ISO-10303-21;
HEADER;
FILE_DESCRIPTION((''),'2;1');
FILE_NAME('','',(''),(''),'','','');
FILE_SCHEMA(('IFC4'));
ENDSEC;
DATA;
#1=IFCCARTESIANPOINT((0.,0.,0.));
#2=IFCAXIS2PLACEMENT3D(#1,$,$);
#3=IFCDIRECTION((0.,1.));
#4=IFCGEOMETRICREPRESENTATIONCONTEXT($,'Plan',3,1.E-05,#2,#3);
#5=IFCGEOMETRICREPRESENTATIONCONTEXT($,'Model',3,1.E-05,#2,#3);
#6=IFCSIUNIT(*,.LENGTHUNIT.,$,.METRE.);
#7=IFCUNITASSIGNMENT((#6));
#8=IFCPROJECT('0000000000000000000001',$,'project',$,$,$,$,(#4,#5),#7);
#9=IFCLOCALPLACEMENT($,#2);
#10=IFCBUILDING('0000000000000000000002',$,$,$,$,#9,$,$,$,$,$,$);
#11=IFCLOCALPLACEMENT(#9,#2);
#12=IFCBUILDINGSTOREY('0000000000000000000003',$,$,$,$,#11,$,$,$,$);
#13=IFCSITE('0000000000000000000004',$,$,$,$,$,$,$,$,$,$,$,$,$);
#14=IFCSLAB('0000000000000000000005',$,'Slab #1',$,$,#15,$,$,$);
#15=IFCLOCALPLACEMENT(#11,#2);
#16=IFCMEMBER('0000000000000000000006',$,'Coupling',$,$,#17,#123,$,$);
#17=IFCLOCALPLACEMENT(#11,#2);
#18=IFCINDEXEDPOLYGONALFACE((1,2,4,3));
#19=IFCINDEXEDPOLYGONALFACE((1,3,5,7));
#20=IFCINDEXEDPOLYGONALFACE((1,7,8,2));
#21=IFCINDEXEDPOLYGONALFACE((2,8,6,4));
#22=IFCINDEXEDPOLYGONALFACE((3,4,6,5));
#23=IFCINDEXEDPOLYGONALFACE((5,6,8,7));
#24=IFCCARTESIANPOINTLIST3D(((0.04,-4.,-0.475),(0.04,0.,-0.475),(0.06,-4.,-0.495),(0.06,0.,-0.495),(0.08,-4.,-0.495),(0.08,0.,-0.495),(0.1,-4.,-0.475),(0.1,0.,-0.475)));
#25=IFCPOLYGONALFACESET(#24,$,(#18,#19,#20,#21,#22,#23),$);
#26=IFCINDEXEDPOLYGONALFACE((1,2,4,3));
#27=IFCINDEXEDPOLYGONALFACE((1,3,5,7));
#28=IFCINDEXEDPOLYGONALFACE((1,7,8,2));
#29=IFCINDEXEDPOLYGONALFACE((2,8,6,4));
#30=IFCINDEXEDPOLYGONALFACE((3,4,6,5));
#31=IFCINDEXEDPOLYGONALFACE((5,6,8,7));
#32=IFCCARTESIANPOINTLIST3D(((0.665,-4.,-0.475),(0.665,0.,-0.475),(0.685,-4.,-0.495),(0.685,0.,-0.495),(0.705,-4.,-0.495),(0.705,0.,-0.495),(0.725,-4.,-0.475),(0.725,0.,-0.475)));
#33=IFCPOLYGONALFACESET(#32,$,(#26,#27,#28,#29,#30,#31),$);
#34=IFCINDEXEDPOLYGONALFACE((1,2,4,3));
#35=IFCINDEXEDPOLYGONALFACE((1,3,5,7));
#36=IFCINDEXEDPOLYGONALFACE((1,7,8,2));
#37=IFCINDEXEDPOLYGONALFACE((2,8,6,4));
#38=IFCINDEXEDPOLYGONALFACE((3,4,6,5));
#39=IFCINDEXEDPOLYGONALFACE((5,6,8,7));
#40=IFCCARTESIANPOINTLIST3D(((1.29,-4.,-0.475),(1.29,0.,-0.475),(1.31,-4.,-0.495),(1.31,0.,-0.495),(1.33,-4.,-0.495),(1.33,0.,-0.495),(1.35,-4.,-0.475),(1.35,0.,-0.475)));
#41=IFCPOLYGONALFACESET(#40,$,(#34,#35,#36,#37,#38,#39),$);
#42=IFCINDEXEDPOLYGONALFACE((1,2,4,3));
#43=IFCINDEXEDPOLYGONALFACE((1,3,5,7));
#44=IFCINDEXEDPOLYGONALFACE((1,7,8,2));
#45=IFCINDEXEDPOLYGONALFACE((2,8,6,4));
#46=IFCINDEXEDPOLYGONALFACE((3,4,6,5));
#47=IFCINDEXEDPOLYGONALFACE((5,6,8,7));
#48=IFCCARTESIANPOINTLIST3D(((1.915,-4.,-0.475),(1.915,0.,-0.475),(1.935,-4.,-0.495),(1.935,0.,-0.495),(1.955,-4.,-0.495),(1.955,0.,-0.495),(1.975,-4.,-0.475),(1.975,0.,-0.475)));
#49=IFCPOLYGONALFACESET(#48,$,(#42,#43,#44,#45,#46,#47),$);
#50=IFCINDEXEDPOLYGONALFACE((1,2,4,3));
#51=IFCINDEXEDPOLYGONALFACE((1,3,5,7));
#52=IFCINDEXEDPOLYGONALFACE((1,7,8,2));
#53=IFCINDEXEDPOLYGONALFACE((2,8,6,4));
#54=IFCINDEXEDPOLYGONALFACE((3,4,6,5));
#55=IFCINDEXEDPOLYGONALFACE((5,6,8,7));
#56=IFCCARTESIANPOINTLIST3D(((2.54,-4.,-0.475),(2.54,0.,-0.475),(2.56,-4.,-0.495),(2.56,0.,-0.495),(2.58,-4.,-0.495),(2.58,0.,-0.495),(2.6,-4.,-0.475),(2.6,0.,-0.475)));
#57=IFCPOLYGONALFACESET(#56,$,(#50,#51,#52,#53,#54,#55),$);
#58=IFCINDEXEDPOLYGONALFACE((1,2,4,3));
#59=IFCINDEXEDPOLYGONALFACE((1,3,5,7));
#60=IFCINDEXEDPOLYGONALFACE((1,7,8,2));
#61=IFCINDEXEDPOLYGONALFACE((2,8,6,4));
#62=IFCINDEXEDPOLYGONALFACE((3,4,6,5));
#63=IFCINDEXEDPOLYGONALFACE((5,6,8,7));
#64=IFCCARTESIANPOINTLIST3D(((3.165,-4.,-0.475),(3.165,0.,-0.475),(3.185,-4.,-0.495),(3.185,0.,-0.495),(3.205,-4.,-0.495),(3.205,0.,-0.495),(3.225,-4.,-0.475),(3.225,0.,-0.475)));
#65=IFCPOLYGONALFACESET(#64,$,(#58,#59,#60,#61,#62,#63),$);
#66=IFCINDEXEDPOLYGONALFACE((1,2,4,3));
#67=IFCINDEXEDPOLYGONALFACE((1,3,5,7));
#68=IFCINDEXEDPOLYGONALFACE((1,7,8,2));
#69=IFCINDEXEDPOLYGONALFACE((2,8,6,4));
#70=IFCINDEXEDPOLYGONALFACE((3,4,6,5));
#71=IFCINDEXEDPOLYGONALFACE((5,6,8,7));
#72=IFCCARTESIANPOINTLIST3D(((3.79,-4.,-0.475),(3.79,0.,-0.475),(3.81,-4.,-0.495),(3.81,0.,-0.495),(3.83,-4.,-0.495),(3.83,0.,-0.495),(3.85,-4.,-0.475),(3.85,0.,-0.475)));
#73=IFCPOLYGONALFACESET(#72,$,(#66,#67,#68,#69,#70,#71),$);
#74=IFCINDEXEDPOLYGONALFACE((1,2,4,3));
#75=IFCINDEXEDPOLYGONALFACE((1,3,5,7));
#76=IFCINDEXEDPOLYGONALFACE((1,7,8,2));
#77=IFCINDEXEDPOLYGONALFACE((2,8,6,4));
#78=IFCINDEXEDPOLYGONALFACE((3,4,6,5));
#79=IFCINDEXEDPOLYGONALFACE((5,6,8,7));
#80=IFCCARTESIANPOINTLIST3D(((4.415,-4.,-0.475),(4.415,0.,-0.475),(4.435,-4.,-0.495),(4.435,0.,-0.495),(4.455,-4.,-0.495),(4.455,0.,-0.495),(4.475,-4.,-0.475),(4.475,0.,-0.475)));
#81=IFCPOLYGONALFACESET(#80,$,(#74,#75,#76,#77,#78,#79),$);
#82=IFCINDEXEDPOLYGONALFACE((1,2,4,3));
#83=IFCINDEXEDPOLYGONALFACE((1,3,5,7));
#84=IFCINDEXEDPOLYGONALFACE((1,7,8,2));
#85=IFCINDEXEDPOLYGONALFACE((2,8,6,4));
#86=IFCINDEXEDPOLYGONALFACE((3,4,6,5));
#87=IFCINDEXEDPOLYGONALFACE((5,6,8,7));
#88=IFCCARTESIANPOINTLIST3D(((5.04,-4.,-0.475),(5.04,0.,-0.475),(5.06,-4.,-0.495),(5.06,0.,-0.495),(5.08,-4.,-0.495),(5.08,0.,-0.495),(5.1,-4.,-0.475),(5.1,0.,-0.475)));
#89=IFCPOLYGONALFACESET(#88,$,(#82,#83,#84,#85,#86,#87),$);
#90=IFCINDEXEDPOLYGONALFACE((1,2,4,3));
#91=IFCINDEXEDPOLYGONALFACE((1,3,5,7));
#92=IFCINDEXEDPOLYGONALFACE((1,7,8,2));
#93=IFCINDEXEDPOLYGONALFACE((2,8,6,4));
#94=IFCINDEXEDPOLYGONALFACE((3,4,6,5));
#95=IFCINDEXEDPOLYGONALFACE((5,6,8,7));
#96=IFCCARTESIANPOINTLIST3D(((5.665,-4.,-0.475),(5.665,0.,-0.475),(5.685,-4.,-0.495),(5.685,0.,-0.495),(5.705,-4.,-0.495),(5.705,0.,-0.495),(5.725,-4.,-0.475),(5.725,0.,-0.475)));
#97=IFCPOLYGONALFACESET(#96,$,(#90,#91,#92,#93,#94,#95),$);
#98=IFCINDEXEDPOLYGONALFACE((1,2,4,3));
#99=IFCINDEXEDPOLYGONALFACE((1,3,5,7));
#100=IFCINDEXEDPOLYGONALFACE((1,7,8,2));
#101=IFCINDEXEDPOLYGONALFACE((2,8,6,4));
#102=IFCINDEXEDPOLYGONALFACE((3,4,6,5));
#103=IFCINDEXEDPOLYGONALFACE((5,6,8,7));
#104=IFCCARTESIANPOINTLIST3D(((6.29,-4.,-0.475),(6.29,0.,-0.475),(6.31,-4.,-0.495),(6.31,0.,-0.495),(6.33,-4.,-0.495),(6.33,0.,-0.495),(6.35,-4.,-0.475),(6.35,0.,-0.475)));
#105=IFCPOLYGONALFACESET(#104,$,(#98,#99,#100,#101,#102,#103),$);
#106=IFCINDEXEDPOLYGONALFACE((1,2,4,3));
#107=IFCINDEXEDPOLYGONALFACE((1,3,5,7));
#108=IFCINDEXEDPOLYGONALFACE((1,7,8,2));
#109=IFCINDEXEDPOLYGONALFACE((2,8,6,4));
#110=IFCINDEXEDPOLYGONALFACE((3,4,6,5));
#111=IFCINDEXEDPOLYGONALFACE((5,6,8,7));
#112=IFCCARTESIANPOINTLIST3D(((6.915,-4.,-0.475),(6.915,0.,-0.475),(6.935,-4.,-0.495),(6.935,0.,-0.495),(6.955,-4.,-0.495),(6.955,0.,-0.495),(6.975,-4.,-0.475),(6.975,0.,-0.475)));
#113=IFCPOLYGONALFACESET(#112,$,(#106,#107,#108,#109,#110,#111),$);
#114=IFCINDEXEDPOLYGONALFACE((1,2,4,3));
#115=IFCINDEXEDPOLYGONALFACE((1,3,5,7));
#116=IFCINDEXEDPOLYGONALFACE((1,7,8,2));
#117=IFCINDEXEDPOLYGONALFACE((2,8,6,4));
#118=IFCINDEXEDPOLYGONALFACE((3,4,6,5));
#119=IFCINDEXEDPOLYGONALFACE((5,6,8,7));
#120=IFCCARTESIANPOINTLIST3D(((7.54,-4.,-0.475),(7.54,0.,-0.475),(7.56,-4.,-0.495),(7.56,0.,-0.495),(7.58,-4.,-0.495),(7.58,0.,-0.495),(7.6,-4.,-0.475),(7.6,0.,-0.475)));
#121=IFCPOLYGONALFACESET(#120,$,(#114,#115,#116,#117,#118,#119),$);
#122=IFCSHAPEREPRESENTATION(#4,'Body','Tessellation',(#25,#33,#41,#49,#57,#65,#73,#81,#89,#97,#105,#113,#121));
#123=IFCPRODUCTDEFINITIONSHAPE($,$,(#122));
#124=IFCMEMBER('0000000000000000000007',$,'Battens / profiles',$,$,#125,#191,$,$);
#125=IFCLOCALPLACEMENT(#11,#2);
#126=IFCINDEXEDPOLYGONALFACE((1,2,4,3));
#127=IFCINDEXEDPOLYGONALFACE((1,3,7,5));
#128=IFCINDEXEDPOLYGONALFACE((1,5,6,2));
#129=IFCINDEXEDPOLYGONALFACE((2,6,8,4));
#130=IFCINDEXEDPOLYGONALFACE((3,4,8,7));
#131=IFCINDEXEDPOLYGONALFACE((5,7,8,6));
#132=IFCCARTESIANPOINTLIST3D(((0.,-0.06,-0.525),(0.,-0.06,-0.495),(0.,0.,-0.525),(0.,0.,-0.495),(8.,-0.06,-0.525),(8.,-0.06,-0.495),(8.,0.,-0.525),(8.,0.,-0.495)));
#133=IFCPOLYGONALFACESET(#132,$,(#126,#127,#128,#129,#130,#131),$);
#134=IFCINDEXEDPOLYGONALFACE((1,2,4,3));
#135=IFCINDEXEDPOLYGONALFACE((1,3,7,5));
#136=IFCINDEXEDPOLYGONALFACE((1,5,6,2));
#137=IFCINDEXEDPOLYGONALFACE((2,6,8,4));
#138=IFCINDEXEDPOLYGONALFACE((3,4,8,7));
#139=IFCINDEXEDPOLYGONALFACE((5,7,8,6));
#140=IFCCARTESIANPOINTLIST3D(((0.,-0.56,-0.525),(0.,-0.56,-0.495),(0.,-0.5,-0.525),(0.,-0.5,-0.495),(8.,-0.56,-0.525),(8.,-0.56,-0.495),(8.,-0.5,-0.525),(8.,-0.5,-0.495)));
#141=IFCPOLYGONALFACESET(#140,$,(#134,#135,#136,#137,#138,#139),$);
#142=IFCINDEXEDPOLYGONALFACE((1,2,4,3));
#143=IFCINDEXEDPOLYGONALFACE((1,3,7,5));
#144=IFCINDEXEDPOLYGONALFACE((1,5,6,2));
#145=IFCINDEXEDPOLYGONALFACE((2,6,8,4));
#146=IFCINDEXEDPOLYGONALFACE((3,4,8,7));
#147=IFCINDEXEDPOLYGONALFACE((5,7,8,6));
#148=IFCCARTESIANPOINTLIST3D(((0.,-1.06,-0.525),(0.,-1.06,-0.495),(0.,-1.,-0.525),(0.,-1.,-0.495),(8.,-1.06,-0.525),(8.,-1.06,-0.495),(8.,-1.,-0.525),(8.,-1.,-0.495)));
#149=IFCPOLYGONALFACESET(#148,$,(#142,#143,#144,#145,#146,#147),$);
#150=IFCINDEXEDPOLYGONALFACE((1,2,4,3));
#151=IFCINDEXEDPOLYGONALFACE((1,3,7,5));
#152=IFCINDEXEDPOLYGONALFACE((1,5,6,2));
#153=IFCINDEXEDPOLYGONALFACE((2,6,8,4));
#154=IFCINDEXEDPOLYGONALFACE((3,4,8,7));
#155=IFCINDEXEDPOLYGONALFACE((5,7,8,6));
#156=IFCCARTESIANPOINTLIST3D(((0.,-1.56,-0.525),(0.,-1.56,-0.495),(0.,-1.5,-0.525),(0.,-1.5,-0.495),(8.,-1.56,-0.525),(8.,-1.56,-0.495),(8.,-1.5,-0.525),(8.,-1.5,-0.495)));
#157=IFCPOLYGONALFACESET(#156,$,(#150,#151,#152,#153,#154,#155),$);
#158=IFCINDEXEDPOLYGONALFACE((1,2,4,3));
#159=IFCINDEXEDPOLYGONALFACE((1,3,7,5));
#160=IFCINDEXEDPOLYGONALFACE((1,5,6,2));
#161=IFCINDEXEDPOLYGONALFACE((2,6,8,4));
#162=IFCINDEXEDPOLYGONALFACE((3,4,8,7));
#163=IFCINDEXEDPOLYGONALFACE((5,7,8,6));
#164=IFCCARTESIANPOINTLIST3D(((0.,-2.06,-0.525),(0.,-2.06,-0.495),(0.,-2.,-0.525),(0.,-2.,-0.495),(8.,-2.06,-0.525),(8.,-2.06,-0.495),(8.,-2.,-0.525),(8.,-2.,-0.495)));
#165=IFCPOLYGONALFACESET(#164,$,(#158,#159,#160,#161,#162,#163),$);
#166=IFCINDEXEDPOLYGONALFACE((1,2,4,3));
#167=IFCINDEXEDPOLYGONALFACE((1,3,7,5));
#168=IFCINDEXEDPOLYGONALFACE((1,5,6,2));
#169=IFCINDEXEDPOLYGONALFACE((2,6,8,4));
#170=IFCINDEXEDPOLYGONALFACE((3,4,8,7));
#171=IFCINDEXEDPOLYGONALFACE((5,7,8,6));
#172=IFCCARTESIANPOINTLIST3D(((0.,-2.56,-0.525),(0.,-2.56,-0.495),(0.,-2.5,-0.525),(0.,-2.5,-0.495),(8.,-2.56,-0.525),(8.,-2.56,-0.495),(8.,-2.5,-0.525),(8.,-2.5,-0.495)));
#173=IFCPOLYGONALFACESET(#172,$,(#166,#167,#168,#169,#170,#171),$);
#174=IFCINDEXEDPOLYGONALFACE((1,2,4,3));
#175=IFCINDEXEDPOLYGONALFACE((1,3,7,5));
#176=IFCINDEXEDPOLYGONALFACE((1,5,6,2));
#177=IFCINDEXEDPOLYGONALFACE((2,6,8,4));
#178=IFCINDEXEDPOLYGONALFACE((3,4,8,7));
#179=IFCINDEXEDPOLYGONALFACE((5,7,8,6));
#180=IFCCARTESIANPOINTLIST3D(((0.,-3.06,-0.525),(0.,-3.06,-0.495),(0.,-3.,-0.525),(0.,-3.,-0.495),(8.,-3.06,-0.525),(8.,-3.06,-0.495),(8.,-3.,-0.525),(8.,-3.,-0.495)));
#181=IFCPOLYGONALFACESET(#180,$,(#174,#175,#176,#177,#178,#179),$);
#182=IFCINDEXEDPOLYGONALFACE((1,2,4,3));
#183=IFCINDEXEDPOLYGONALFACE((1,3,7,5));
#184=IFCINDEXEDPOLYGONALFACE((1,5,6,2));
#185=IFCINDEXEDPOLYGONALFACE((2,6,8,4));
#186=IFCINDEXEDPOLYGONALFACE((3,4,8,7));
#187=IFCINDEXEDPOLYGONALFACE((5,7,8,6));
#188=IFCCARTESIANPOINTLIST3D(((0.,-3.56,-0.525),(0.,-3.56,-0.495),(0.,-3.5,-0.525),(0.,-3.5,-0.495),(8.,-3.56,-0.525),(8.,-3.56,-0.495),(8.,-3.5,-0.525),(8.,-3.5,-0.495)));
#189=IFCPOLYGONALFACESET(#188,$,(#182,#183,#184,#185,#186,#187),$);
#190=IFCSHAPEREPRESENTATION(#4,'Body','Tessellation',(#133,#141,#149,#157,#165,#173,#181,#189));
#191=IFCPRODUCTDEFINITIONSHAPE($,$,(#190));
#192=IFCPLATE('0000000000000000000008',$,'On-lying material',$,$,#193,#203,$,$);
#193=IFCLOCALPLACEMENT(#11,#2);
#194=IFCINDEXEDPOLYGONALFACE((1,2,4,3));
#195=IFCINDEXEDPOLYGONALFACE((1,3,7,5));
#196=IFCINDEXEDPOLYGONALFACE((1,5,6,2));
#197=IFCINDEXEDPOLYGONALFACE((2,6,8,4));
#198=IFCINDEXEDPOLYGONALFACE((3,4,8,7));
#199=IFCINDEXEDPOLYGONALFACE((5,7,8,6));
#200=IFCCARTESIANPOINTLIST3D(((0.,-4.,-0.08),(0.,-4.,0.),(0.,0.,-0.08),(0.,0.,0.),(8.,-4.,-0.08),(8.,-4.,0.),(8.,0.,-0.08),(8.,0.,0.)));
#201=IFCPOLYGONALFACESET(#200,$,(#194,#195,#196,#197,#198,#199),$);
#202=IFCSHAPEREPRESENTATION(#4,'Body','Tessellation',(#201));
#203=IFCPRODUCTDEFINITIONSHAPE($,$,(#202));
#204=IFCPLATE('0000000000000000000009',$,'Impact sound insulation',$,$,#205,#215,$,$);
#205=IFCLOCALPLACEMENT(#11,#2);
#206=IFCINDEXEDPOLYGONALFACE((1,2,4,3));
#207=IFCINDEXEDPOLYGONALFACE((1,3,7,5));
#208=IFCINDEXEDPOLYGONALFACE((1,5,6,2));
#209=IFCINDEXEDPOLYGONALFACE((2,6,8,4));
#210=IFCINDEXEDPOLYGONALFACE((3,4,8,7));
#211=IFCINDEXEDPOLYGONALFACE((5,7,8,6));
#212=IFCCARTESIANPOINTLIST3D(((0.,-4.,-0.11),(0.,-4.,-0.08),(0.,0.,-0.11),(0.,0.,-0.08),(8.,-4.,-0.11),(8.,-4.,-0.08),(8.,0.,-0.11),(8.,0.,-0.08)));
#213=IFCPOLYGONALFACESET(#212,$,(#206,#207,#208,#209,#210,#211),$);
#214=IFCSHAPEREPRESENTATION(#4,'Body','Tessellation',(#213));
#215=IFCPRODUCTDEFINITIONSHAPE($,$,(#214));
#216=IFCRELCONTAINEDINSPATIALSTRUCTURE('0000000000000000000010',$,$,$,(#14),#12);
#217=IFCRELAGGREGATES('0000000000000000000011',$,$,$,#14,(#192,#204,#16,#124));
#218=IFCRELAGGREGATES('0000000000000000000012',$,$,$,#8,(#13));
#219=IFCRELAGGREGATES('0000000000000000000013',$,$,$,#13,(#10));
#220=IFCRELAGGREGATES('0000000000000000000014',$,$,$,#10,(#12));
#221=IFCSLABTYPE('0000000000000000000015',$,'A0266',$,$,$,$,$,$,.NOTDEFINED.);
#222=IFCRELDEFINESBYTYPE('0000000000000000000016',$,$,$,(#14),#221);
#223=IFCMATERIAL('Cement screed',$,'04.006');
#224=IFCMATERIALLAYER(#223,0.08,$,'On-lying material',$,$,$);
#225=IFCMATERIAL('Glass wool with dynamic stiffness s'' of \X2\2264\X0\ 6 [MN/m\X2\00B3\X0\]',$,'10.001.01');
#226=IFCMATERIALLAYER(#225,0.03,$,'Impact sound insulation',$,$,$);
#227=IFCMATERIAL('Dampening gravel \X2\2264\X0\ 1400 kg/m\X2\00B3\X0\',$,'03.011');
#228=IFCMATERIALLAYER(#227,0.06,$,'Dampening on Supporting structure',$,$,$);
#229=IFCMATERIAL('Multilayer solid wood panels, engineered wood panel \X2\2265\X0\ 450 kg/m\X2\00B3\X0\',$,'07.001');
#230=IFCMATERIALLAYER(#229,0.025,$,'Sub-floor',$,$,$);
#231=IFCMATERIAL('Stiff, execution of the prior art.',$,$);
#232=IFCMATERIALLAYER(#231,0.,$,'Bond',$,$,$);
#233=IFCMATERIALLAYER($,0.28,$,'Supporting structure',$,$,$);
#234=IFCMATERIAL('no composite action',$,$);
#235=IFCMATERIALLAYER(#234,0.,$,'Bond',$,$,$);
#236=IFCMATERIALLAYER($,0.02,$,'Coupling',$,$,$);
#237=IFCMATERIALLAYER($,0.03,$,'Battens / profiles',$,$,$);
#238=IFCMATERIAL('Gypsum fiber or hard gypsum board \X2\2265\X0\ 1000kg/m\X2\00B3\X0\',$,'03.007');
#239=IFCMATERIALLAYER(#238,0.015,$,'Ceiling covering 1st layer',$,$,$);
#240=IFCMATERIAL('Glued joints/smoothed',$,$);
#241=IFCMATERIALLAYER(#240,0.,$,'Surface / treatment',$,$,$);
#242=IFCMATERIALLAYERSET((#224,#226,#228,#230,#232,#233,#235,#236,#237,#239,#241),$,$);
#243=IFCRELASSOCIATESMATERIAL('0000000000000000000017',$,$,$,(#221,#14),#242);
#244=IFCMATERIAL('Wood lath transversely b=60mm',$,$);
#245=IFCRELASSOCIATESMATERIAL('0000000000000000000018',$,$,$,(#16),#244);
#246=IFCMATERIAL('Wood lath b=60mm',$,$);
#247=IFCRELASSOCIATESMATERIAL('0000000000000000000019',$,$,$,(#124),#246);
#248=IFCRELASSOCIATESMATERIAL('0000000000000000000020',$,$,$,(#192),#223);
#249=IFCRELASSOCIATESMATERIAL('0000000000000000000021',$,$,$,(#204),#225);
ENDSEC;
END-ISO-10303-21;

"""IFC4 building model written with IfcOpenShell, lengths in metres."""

from ifc_helpers import new_model, si_unit, direction, frame, frame_2d, origin, origin_with_axes, place, context, project, spatial, polyline, rectangle, outline, extrude, material, layer, layer_set, type_object, element, aggregate, save


model = new_model("IFC4")

# Units and contexts
plan_context = context("Plan", 3, precision=1e-05, world=origin(), true_north=direction((0.0, 1.0)))
model_context = context("Model", 3, precision=1e-05, world=origin(), true_north=direction((0.0, 1.0)))
ifc_project = project(units=[si_unit("LENGTHUNIT", "METRE")], contexts=[plan_context, model_context])

# Site, building, storey
site = spatial("IfcSite", under=ifc_project)
building_placement = place(None, origin())
building = spatial("IfcBuilding", under=site, at=building_placement)
storey_placement = place(building_placement, origin())
storey = spatial("IfcBuildingStorey", under=building, at=storey_placement)

# Slab, members, plates
ifc_material_1 = material(Name="Cement screed", Category="04.006")
ifc_layer_1 = layer(ifc_material_1, 0.08, Name="On-lying material")
ifc_material_2 = material(Name="Glass wool with dynamic stiffness s' of ≤ 6 [MN/m³]", Category="10.001.01")
ifc_layer_2 = layer(ifc_material_2, 0.03, Name="Impact sound insulation")
ifc_material_3 = material(Name="Dampening gravel ≤ 1400 kg/m³", Category="03.011")
ifc_layer_3 = layer(ifc_material_3, 0.06, Name="Dampening on Supporting structure")
ifc_material_4 = material(Name="Multilayer solid wood panels, engineered wood panel ≥ 450 kg/m³", Category="07.001")
ifc_layer_4 = layer(ifc_material_4, 0.025, Name="Sub-floor")
ifc_material_5 = material(Name="Stiff, execution of the prior art.")
ifc_layer_5 = layer(ifc_material_5, 0.0, Name="Bond")
ifc_layer_6 = layer(None, 0.28, Name="Supporting structure")
ifc_material_6 = material(Name="no composite action")
ifc_layer_7 = layer(ifc_material_6, 0.0, Name="Bond")
ifc_layer_8 = layer(None, 0.02, Name="Coupling")
ifc_layer_9 = layer(None, 0.03, Name="Battens / profiles")
ifc_material_7 = material(Name="Gypsum fiber or hard gypsum board ≥ 1000kg/m³", Category="03.007")
ifc_layer_10 = layer(ifc_material_7, 0.015, Name="Ceiling covering 1st layer")
ifc_material_8 = material(Name="Glued joints/smoothed")
ifc_layer_11 = layer(ifc_material_8, 0.0, Name="Surface / treatment")
ifc_layer_set = layer_set([ifc_layer_1, ifc_layer_2, ifc_layer_3, ifc_layer_4, ifc_layer_5, ifc_layer_6, ifc_layer_7, ifc_layer_8, ifc_layer_9, ifc_layer_10, ifc_layer_11])
slab_type = type_object("IfcSlabType", Name="A0266", PredefinedType="NOTDEFINED", material=ifc_layer_set)
slab_placement = place(None, frame((0.0, 0.0, 0.0), z_axis=(0.0, 0.0, -1.0), x_axis=(1.0, 0.0, 0.0)))
slab = element("IfcSlab", 1, at=slab_placement, inside=storey, type_object=slab_type, material=ifc_layer_set, Name="Slab #1")
ifc_material_9 = material(Name="Wood lath transversely b=60mm")
member_1_placement = place(slab_placement, origin())
member_1 = element("IfcMember", 2, at=member_1_placement, material=ifc_material_9, Name="Coupling", context=plan_context, shape_type="SweptSolid", body=[
    extrude(outline(polyline([(0.0, 0.0), (0.06, 0.0), (0.04, 0.02), (0.02, 0.02), (0.0, 0.0)])), frame((0.04, 4.0, 0.475), z_axis=(0.0, -1.0, 0.0), x_axis=(1.0, 0.0, 0.0)), (0.0, 0.0, 1.0), 4.0),
    extrude(outline(polyline([(0.0, 0.0), (0.06, 0.0), (0.04, 0.02), (0.02, 0.02), (0.0, 0.0)])), frame((0.665, 4.0, 0.475), z_axis=(0.0, -1.0, 0.0), x_axis=(1.0, 0.0, 0.0)), (0.0, 0.0, 1.0), 4.0),
    extrude(outline(polyline([(0.0, 0.0), (0.06, 0.0), (0.04, 0.02), (0.02, 0.02), (0.0, 0.0)])), frame((1.29, 4.0, 0.475), z_axis=(0.0, -1.0, 0.0), x_axis=(1.0, 0.0, 0.0)), (0.0, 0.0, 1.0), 4.0),
    extrude(outline(polyline([(0.0, 0.0), (0.06, 0.0), (0.04, 0.02), (0.02, 0.02), (0.0, 0.0)])), frame((1.915, 4.0, 0.475), z_axis=(0.0, -1.0, 0.0), x_axis=(1.0, 0.0, 0.0)), (0.0, 0.0, 1.0), 4.0),
    extrude(outline(polyline([(0.0, 0.0), (0.06, 0.0), (0.04, 0.02), (0.02, 0.02), (0.0, 0.0)])), frame((2.54, 4.0, 0.475), z_axis=(0.0, -1.0, 0.0), x_axis=(1.0, 0.0, 0.0)), (0.0, 0.0, 1.0), 4.0),
    extrude(outline(polyline([(0.0, 0.0), (0.06, 0.0), (0.04, 0.02), (0.02, 0.02), (0.0, 0.0)])), frame((3.165, 4.0, 0.475), z_axis=(0.0, -1.0, 0.0), x_axis=(1.0, 0.0, 0.0)), (0.0, 0.0, 1.0), 4.0),
    extrude(outline(polyline([(0.0, 0.0), (0.06, 0.0), (0.04, 0.02), (0.02, 0.02), (0.0, 0.0)])), frame((3.79, 4.0, 0.475), z_axis=(0.0, -1.0, 0.0), x_axis=(1.0, 0.0, 0.0)), (0.0, 0.0, 1.0), 4.0),
    extrude(outline(polyline([(0.0, 0.0), (0.06, 0.0), (0.04, 0.02), (0.02, 0.02), (0.0, 0.0)])), frame((4.415, 4.0, 0.475), z_axis=(0.0, -1.0, 0.0), x_axis=(1.0, 0.0, 0.0)), (0.0, 0.0, 1.0), 4.0),
    extrude(outline(polyline([(0.0, 0.0), (0.06, 0.0), (0.04, 0.02), (0.02, 0.02), (0.0, 0.0)])), frame((5.04, 4.0, 0.475), z_axis=(0.0, -1.0, 0.0), x_axis=(1.0, 0.0, 0.0)), (0.0, 0.0, 1.0), 4.0),
    extrude(outline(polyline([(0.0, 0.0), (0.06, 0.0), (0.04, 0.02), (0.02, 0.02), (0.0, 0.0)])), frame((5.665, 4.0, 0.475), z_axis=(0.0, -1.0, 0.0), x_axis=(1.0, 0.0, 0.0)), (0.0, 0.0, 1.0), 4.0),
    extrude(outline(polyline([(0.0, 0.0), (0.06, 0.0), (0.04, 0.02), (0.02, 0.02), (0.0, 0.0)])), frame((6.29, 4.0, 0.475), z_axis=(0.0, -1.0, 0.0), x_axis=(1.0, 0.0, 0.0)), (0.0, 0.0, 1.0), 4.0),
    extrude(outline(polyline([(0.0, 0.0), (0.06, 0.0), (0.04, 0.02), (0.02, 0.02), (0.0, 0.0)])), frame((6.915, 4.0, 0.475), z_axis=(0.0, -1.0, 0.0), x_axis=(1.0, 0.0, 0.0)), (0.0, 0.0, 1.0), 4.0),
    extrude(outline(polyline([(0.0, 0.0), (0.06, 0.0), (0.04, 0.02), (0.02, 0.02), (0.0, 0.0)])), frame((7.54, 4.0, 0.475), z_axis=(0.0, -1.0, 0.0), x_axis=(1.0, 0.0, 0.0)), (0.0, 0.0, 1.0), 4.0),
])
ifc_material_10 = material(Name="Wood lath b=60mm")
member_2_placement = place(slab_placement, origin())
member_2 = element("IfcMember", 3, at=member_2_placement, material=ifc_material_10, Name="Battens / profiles", context=plan_context, shape_type="SweptSolid", body=[
    extrude(rectangle(XDim=0.06, YDim=0.03, at=frame_2d((0.03, 0.015), x_axis=(1.0, 0.0))), frame((0.0, 0.0, 0.495), z_axis=(1.0, 0.0, 0.0), x_axis=(0.0, 1.0, 0.0)), (0.0, 0.0, 1.0), 8.0),
    extrude(rectangle(XDim=0.06, YDim=0.03, at=frame_2d((0.03, 0.015), x_axis=(1.0, 0.0))), frame((0.0, 0.5, 0.495), z_axis=(1.0, 0.0, 0.0), x_axis=(0.0, 1.0, 0.0)), (0.0, 0.0, 1.0), 8.0),
    extrude(rectangle(XDim=0.06, YDim=0.03, at=frame_2d((0.03, 0.015), x_axis=(1.0, 0.0))), frame((0.0, 1.0, 0.495), z_axis=(1.0, 0.0, 0.0), x_axis=(0.0, 1.0, 0.0)), (0.0, 0.0, 1.0), 8.0),
    extrude(rectangle(XDim=0.06, YDim=0.03, at=frame_2d((0.03, 0.015), x_axis=(1.0, 0.0))), frame((0.0, 1.5, 0.495), z_axis=(1.0, 0.0, 0.0), x_axis=(0.0, 1.0, 0.0)), (0.0, 0.0, 1.0), 8.0),
    extrude(rectangle(XDim=0.06, YDim=0.03, at=frame_2d((0.03, 0.015), x_axis=(1.0, 0.0))), frame((0.0, 2.0, 0.495), z_axis=(1.0, 0.0, 0.0), x_axis=(0.0, 1.0, 0.0)), (0.0, 0.0, 1.0), 8.0),
    extrude(rectangle(XDim=0.06, YDim=0.03, at=frame_2d((0.03, 0.015), x_axis=(1.0, 0.0))), frame((0.0, 2.5, 0.495), z_axis=(1.0, 0.0, 0.0), x_axis=(0.0, 1.0, 0.0)), (0.0, 0.0, 1.0), 8.0),
    extrude(rectangle(XDim=0.06, YDim=0.03, at=frame_2d((0.03, 0.015), x_axis=(1.0, 0.0))), frame((0.0, 3.0, 0.495), z_axis=(1.0, 0.0, 0.0), x_axis=(0.0, 1.0, 0.0)), (0.0, 0.0, 1.0), 8.0),
    extrude(rectangle(XDim=0.06, YDim=0.03, at=frame_2d((0.03, 0.015), x_axis=(1.0, 0.0))), frame((0.0, 3.5, 0.495), z_axis=(1.0, 0.0, 0.0), x_axis=(0.0, 1.0, 0.0)), (0.0, 0.0, 1.0), 8.0),
])
plate_1_placement = place(slab_placement, origin())
plate_1 = element("IfcPlate", 4, at=plate_1_placement, material=ifc_material_1, Name="On-lying material", context=plan_context, shape_type="SweptSolid", body=[
    extrude(rectangle(XDim=8.0, YDim=4.0, at=frame_2d((4.0, 2.0), x_axis=(1.0, 0.0))), origin_with_axes(), (0.0, 0.0, 1.0), 0.08),
])
plate_2_placement = place(slab_placement, origin())
plate_2 = element("IfcPlate", 5, at=plate_2_placement, material=ifc_material_2, Name="Impact sound insulation", context=plan_context, shape_type="SweptSolid", body=[
    extrude(rectangle(XDim=8.0, YDim=4.0, at=frame_2d((4.0, 2.0), x_axis=(1.0, 0.0))), frame((0.0, 0.0, 0.08), z_axis=(0.0, 0.0, 1.0), x_axis=(1.0, 0.0, 0.0)), (0.0, 0.0, 1.0), 0.03),
])
aggregate(slab, [plate_1, plate_2, member_1, member_2])

save(model, "model.ifc")
